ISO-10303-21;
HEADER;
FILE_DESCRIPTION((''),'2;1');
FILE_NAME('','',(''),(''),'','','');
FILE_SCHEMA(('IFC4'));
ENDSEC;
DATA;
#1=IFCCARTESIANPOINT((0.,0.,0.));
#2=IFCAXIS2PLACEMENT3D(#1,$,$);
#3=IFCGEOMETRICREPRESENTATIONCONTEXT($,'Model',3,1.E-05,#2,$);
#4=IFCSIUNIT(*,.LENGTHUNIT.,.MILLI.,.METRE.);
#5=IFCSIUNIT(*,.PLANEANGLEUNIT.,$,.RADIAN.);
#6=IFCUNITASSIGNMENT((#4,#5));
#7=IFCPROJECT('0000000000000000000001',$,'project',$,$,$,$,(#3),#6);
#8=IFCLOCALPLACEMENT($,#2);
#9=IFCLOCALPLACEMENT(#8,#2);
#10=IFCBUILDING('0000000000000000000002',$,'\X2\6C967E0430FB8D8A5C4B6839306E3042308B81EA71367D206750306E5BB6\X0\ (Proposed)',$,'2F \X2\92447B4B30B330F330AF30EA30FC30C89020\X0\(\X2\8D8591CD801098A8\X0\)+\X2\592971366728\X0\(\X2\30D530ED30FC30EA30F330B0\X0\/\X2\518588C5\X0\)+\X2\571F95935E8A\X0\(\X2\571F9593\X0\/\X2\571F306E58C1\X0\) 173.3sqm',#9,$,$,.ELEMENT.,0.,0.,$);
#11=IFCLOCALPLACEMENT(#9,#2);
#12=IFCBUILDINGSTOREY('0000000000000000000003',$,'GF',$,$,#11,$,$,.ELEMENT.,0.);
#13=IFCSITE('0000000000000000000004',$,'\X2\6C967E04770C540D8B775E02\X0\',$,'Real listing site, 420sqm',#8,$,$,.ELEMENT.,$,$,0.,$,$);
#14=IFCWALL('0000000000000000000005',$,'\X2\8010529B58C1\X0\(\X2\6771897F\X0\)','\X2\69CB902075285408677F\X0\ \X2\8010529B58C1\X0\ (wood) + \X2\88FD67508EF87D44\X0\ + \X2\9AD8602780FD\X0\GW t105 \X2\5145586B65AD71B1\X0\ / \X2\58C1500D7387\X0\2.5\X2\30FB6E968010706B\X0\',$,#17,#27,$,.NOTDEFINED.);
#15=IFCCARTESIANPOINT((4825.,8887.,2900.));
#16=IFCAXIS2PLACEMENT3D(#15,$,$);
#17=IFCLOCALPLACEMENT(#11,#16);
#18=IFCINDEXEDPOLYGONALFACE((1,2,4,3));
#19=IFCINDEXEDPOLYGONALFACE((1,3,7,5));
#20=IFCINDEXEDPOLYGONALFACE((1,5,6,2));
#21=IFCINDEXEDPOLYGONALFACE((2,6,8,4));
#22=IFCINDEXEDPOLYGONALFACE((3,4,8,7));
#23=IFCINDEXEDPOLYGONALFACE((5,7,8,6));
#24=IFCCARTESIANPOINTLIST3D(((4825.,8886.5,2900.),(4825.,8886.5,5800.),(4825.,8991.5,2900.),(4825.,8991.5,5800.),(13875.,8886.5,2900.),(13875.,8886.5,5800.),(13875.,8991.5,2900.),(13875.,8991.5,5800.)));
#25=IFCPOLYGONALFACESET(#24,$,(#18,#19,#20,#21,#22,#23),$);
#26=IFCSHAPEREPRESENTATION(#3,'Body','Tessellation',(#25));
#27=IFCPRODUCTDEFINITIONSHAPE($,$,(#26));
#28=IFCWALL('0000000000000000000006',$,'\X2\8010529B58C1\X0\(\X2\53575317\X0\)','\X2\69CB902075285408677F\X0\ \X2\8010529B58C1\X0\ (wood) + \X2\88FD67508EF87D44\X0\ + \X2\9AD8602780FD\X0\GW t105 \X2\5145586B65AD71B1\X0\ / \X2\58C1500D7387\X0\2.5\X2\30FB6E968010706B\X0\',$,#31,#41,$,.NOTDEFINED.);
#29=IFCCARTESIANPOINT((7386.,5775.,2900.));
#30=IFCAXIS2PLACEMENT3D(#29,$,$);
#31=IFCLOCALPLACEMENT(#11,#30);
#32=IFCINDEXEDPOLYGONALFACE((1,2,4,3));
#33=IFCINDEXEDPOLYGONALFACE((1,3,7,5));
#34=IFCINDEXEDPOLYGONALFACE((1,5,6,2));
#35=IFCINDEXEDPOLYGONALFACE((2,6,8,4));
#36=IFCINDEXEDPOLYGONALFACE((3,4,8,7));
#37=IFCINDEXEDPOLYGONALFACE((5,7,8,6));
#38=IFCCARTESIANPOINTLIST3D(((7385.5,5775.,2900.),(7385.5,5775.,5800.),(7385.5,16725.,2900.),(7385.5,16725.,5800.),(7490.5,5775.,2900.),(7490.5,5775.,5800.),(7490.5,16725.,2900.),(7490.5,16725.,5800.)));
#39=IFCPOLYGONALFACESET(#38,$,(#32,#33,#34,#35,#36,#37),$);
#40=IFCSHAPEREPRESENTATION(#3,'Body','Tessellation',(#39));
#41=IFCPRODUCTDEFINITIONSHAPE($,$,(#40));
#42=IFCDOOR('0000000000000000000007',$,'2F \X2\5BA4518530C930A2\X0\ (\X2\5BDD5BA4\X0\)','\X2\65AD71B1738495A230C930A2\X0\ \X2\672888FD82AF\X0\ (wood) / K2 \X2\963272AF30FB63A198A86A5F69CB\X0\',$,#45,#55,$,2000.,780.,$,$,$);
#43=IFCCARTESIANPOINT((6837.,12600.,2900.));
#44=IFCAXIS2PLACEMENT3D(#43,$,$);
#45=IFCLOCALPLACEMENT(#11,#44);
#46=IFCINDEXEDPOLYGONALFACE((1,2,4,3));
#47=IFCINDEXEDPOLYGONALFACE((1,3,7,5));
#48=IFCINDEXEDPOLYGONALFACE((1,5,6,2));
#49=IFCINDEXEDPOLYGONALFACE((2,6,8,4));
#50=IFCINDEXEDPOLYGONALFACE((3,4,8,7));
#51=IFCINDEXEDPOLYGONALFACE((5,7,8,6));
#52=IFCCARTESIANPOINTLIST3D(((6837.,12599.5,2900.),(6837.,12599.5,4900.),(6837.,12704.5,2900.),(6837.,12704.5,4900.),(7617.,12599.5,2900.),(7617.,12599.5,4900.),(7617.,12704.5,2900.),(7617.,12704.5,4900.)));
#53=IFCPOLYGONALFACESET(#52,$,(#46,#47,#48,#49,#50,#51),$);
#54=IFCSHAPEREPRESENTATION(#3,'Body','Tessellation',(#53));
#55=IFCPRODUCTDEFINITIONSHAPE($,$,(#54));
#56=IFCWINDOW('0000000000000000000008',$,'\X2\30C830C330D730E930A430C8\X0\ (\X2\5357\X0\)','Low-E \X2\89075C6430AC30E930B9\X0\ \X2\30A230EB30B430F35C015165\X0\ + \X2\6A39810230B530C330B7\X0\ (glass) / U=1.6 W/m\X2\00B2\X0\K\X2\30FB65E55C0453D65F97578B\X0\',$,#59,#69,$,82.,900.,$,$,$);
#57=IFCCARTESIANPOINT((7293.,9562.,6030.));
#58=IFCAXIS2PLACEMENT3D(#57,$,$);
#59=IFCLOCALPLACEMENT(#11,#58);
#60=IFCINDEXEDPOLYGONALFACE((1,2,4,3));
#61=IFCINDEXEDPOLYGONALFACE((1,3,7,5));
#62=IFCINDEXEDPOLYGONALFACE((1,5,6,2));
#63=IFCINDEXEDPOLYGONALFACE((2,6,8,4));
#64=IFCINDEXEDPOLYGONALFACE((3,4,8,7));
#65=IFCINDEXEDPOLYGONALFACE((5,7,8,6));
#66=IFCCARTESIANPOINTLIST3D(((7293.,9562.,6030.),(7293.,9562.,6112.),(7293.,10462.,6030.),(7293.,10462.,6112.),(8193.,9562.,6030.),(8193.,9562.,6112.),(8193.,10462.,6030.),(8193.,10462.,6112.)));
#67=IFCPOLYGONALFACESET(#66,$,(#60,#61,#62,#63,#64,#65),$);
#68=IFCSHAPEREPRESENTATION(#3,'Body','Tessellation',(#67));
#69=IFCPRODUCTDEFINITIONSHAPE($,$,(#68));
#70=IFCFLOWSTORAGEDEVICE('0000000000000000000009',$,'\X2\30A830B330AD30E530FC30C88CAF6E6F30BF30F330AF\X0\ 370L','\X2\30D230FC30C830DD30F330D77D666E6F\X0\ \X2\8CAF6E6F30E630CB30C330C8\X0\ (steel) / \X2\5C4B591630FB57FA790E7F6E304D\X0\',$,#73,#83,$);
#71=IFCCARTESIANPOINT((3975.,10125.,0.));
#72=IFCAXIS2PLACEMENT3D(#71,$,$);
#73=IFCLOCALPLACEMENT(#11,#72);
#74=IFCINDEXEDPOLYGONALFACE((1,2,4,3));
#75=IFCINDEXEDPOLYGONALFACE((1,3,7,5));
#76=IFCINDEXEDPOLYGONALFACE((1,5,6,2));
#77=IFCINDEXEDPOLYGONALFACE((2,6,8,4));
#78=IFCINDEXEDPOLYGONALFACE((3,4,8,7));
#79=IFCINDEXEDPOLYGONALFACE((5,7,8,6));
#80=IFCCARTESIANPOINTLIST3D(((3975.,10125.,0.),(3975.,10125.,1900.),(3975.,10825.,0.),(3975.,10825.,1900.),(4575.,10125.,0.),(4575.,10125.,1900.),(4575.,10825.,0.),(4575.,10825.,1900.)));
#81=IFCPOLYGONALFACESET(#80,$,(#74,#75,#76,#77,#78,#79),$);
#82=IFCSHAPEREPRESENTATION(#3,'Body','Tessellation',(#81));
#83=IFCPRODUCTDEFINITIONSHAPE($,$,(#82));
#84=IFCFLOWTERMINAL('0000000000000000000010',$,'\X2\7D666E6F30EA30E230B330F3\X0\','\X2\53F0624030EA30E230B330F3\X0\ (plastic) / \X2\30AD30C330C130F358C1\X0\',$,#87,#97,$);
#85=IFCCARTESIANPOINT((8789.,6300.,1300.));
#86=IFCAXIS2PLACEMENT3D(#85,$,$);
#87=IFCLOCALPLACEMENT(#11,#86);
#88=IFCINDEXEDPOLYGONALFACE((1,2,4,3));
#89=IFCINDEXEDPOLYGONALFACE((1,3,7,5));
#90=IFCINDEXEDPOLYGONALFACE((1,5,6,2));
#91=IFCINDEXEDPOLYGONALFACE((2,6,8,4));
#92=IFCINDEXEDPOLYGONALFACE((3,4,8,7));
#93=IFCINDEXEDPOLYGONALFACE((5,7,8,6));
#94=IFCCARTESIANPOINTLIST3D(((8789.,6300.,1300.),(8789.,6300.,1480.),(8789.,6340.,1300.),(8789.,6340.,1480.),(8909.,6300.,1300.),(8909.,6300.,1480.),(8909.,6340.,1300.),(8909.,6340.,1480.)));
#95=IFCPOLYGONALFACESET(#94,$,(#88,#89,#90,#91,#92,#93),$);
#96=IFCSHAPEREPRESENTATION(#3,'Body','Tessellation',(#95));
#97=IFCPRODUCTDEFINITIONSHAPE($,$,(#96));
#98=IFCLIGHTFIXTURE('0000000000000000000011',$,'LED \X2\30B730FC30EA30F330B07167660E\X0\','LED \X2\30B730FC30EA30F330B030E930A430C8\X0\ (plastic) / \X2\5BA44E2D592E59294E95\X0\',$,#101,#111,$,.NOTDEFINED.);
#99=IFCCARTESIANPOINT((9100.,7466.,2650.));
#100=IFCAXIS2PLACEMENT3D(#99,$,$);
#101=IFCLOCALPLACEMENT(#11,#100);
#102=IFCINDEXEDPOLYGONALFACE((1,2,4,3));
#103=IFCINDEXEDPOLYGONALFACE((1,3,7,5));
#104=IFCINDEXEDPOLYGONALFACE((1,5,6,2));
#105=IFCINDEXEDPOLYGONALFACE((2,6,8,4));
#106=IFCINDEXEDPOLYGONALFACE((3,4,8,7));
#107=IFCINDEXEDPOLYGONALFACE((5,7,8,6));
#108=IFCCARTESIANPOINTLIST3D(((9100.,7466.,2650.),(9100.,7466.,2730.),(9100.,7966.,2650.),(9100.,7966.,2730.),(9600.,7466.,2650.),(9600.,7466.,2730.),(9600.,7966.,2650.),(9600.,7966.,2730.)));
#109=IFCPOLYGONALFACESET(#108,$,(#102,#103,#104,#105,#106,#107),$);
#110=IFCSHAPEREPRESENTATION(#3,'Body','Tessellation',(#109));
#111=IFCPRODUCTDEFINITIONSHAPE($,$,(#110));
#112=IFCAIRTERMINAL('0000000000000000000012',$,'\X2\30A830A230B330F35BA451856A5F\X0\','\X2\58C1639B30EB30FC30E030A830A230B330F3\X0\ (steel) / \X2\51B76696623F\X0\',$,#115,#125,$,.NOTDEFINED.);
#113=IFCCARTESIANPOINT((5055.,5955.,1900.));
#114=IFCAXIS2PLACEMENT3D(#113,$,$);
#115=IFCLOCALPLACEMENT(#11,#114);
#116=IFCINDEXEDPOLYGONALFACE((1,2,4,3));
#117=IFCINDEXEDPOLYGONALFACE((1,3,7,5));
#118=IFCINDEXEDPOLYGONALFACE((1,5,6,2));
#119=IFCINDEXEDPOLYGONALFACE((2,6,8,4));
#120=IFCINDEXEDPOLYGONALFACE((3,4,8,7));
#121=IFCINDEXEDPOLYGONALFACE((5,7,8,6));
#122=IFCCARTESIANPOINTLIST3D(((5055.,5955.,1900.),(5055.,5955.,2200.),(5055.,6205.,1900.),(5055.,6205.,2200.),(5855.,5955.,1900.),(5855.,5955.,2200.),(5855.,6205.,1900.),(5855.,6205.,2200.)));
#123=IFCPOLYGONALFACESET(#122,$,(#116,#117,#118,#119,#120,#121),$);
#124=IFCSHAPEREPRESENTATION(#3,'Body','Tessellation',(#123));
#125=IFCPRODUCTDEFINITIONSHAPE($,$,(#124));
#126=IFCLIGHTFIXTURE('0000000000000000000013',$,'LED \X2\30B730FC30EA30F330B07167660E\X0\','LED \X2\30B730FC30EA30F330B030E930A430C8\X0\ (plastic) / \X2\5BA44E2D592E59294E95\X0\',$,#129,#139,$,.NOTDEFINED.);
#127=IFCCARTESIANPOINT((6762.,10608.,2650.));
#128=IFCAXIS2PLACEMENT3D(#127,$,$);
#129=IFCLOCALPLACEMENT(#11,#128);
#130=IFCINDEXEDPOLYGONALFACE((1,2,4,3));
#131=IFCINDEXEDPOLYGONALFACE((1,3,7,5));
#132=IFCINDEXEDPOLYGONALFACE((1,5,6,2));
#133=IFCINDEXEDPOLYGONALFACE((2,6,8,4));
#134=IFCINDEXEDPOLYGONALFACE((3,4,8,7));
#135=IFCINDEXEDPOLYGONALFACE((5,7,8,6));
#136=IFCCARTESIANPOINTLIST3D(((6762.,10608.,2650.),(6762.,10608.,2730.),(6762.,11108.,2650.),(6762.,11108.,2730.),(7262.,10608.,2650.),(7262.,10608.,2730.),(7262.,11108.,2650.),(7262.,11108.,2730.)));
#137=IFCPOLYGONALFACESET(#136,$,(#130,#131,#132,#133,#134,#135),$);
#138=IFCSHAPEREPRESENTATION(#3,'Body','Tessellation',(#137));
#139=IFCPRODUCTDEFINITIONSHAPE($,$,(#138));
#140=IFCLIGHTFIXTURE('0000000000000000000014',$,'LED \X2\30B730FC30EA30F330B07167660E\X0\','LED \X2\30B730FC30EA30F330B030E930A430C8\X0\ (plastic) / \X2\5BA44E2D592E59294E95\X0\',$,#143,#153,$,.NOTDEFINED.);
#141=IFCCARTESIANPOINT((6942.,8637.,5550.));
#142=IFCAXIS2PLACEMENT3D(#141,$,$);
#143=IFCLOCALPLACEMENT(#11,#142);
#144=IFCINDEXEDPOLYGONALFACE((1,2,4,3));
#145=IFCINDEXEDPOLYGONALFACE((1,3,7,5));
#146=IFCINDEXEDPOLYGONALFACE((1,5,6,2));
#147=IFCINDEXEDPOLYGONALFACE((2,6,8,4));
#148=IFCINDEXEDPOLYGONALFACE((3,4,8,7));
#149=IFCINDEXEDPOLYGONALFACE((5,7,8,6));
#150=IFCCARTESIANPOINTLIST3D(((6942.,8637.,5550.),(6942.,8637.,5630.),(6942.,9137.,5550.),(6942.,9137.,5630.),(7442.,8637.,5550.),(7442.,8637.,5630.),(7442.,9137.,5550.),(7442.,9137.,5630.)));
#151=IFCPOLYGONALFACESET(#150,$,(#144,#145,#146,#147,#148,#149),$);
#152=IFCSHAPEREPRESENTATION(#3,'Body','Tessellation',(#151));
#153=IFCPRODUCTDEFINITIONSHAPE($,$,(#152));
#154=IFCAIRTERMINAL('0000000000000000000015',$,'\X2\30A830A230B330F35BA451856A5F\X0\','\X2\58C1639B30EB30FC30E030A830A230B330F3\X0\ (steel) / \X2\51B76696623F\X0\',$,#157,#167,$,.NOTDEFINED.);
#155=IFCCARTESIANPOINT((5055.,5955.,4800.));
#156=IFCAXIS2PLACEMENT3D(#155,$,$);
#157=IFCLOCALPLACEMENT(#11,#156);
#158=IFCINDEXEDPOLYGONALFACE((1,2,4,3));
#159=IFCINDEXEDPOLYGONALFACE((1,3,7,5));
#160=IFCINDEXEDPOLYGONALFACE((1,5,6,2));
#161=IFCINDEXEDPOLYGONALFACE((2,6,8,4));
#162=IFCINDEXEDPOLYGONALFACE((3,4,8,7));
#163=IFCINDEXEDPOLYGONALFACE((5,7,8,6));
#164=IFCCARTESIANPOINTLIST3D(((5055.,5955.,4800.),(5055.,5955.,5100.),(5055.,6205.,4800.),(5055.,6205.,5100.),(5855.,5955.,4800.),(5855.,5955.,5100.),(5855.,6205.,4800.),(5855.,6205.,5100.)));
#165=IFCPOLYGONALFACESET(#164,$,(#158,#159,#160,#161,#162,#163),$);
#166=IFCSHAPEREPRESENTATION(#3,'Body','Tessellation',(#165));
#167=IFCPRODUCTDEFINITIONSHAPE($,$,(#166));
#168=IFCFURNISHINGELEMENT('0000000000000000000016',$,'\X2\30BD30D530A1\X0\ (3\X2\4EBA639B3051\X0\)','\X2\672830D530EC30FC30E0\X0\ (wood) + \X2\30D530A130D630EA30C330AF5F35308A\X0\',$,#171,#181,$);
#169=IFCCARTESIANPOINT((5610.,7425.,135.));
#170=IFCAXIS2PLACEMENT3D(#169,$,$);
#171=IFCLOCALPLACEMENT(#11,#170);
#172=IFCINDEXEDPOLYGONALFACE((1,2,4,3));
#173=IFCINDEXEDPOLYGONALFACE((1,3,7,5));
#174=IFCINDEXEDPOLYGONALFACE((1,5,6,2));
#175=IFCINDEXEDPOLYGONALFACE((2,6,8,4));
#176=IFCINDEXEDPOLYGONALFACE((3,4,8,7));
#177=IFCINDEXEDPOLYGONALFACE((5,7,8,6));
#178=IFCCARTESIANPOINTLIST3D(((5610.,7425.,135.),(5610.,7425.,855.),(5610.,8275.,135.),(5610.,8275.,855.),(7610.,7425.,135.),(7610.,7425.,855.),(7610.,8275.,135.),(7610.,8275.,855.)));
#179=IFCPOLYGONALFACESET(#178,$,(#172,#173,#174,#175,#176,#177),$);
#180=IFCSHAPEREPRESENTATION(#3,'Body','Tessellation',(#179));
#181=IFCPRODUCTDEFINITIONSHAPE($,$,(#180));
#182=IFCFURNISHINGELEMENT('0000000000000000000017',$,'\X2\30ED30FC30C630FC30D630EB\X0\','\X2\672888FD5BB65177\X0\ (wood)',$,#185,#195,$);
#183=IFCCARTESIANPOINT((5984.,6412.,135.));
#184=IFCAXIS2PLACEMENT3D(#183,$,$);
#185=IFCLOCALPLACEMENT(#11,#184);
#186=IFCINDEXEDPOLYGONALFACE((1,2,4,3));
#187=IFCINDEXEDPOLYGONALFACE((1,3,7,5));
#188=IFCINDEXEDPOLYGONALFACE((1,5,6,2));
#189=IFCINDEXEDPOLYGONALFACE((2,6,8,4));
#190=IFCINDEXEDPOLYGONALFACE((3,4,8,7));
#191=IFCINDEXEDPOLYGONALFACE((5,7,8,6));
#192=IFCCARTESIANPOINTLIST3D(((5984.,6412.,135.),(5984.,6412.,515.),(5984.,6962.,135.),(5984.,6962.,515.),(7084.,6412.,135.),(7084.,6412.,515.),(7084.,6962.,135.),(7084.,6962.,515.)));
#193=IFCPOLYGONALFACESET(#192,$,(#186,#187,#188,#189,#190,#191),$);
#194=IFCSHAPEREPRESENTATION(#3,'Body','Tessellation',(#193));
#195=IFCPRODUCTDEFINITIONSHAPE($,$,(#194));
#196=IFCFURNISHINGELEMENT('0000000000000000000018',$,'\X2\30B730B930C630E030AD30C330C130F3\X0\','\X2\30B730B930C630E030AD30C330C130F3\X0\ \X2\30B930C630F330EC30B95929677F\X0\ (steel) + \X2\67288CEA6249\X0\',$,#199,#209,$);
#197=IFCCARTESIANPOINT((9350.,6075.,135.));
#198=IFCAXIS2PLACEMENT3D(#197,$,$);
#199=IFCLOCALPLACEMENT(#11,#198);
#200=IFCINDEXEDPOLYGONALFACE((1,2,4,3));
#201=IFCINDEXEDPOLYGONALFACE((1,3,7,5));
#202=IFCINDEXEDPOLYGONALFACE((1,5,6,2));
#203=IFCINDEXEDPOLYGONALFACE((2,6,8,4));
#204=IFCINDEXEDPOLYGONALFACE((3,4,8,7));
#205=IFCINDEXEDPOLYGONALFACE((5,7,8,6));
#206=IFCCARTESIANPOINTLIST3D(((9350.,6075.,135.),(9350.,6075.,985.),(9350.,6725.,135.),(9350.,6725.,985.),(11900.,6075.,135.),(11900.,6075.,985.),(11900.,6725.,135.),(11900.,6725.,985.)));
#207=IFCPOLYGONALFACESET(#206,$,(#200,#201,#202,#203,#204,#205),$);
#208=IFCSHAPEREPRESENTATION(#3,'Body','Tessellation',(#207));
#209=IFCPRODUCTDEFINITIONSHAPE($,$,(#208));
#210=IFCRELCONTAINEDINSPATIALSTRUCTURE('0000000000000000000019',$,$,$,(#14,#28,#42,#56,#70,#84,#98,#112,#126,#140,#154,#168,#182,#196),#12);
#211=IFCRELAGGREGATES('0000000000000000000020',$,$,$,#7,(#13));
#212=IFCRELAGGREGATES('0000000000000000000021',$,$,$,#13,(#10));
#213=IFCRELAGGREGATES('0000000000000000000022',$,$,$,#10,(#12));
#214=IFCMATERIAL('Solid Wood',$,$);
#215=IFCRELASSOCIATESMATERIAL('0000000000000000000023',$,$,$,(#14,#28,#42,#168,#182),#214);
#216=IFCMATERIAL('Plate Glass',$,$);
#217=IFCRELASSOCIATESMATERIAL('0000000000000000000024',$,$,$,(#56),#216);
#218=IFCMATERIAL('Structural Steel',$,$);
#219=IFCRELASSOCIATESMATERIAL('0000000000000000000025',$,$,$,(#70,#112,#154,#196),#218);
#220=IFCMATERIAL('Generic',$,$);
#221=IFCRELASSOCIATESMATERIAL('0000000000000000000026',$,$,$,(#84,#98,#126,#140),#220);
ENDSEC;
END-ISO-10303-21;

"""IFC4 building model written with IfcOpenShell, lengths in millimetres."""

from ifc_helpers import new_model, si_unit, frame, frame_2d, origin, place, context, project, spatial, rectangle, extrude, material, element, fill, save


model = new_model("IFC4")

# Units and contexts
model_context = context("Model", 3, precision=1e-05, world=origin())
ifc_project = project(units=[si_unit("LENGTHUNIT", "METRE", prefix="MILLI"), si_unit("PLANEANGLEUNIT", "RADIAN")], contexts=[model_context])

# Site, building, storey
site_placement = place(None, origin())
site = spatial("IfcSite", under=ifc_project, at=site_placement, Name="沖縄県名護市", ObjectType="Real listing site, 420sqm", CompositionType="ELEMENT", RefElevation=0.0)
building_placement = place(site_placement, origin())
building = spatial("IfcBuilding", under=site, at=building_placement, Name="沖縄・越屋根のある自然素材の家 (Proposed)", ObjectType="2F 鉄筋コンクリート造(超重耐風)+天然木(フローリング/内装)+土間床(土間/土の壁) 173.3sqm", CompositionType="ELEMENT", ElevationOfRefHeight=0.0, ElevationOfTerrain=0.0)
storey_placement = place(building_placement, origin())
storey = spatial("IfcBuildingStorey", under=building, at=storey_placement, Name="GF", CompositionType="ELEMENT", Elevation=0.0)

# Shared definitions
ifc_material_1 = material(Name="Solid Wood")

# Wall
wall_1_placement = place(storey_placement, frame((4825.0, 8887.0, 2900.0)))
element("IfcWall", 1, at=wall_1_placement, inside=storey, material=ifc_material_1, Name="耐力壁(東西)", Description="構造用合板 耐力壁 (wood) + 製材軸組 + 高性能GW t105 充填断熱 / 壁倍率2.5・準耐火", PredefinedType="NOTDEFINED", context=model_context, shape_type="SweptSolid", body=[
    extrude(rectangle(XDim=9050.0, YDim=105.0, at=frame_2d((4525.0, 52.0))), frame((4825.0, 8887.0, 2900.0)), (0.0, 0.0, 1.0), 2900.0),
])

# Wall, opening, door
wall_2_placement = place(storey_placement, frame((7386.0, 5775.0, 2900.0)))
wall_2 = element("IfcWall", 2, at=wall_2_placement, inside=storey, material=ifc_material_1, Name="耐力壁(南北)", Description="構造用合板 耐力壁 (wood) + 製材軸組 + 高性能GW t105 充填断熱 / 壁倍率2.5・準耐火", PredefinedType="NOTDEFINED", context=model_context, shape_type="SweptSolid", body=[
    extrude(rectangle(XDim=105.0, YDim=10950.0, at=frame_2d((52.0, 5475.0))), frame((7386.0, 5775.0, 2900.0)), (0.0, 0.0, 1.0), 2900.0),
])
opening_placement = place(storey_placement, frame((6837.0, 12600.0, 2900.0)))
opening = element("IfcOpeningElement", 3, at=opening_placement, cuts=wall_2, PredefinedType="NOTDEFINED", context=model_context, shape_type="SweptSolid", body=[
    extrude(rectangle(XDim=780.0, YDim=105.0, at=frame_2d((390.0, 52.0))), frame((6837.0, 12600.0, 2900.0)), (0.0, 0.0, 1.0), 2000.0),
])
door_placement = place(storey_placement, frame((6837.0, 12600.0, 2900.0)))
door = element("IfcDoor", 4, at=door_placement, inside=storey, material=ifc_material_1, Name="2F 室内ドア (寝室)", Description="断熱玄関ドア 木製芯 (wood) / K2 防犯・採風機構", OverallHeight=2000.0, OverallWidth=780.0, context=model_context, shape_type="SweptSolid", body=[
    extrude(rectangle(XDim=780.0, YDim=105.0, at=frame_2d((390.0, 52.0))), frame((6837.0, 12600.0, 2900.0)), (0.0, 0.0, 1.0), 2000.0),
])
fill(opening, door)

# Window
ifc_material_2 = material(Name="Plate Glass")
window_placement = place(storey_placement, frame((7293.0, 9562.0, 6030.0)))
element("IfcWindow", 5, at=window_placement, inside=storey, material=ifc_material_2, Name="トップライト (南)", Description="Low-E 複層ガラス アルゴン封入 + 樹脂サッシ (glass) / U=1.6 W/m²K・日射取得型", OverallHeight=82.0, OverallWidth=900.0, context=model_context, shape_type="SweptSolid", body=[
    extrude(rectangle(XDim=900.0, YDim=900.0, at=frame_2d((450.0, 450.0))), frame((7293.0, 9562.0, 6030.0)), (0.0, 0.0, 1.0), 82.0),
])

# Flow storage device
ifc_material_3 = material(Name="Structural Steel")
flow_storage_device_placement = place(storey_placement, frame((3975.0, 10125.0, 0.0)))
element("IfcFlowStorageDevice", 6, at=flow_storage_device_placement, inside=storey, material=ifc_material_3, Name="エコキュート貯湯タンク 370L", Description="ヒートポンプ給湯 貯湯ユニット (steel) / 屋外・基礎置き", context=model_context, shape_type="SweptSolid", body=[
    extrude(rectangle(XDim=600.0, YDim=700.0, at=frame_2d((300.0, 350.0))), frame((3975.0, 10125.0, 0.0)), (0.0, 0.0, 1.0), 1900.0),
])

# Flow terminal
ifc_material_4 = material(Name="Generic")
flow_terminal_placement = place(storey_placement, frame((8789.0, 6300.0, 1300.0)))
element("IfcFlowTerminal", 7, at=flow_terminal_placement, inside=storey, material=ifc_material_4, Name="給湯リモコン", Description="台所リモコン (plastic) / キッチン壁", context=model_context, shape_type="SweptSolid", body=[
    extrude(rectangle(XDim=120.0, YDim=40.0, at=frame_2d((60.0, 20.0))), frame((8789.0, 6300.0, 1300.0)), (0.0, 0.0, 1.0), 180.0),
])

# Light fixture
light_fixture_1_placement = place(storey_placement, frame((9100.0, 7466.0, 2650.0)))
element("IfcLightFixture", 8, at=light_fixture_1_placement, inside=storey, material=ifc_material_4, Name="LED シーリング照明", Description="LED シーリングライト (plastic) / 室中央天井", PredefinedType="NOTDEFINED", context=model_context, shape_type="SweptSolid", body=[
    extrude(rectangle(XDim=500.0, YDim=500.0, at=frame_2d((250.0, 250.0))), frame((9100.0, 7466.0, 2650.0)), (0.0, 0.0, 1.0), 80.0),
])

# Air terminal
air_terminal_1_placement = place(storey_placement, frame((5055.0, 5955.0, 1900.0)))
element("IfcAirTerminal", 9, at=air_terminal_1_placement, inside=storey, material=ifc_material_3, Name="エアコン室内機", Description="壁掛ルームエアコン (steel) / 冷暖房", PredefinedType="NOTDEFINED", context=model_context, shape_type="SweptSolid", body=[
    extrude(rectangle(XDim=800.0, YDim=250.0, at=frame_2d((400.0, 125.0))), frame((5055.0, 5955.0, 1900.0)), (0.0, 0.0, 1.0), 300.0),
])

# Light fixtures
light_fixture_2_placement = place(storey_placement, frame((6762.0, 10608.0, 2650.0)))
element("IfcLightFixture", 10, at=light_fixture_2_placement, inside=storey, material=ifc_material_4, Name="LED シーリング照明", Description="LED シーリングライト (plastic) / 室中央天井", PredefinedType="NOTDEFINED", context=model_context, shape_type="SweptSolid", body=[
    extrude(rectangle(XDim=500.0, YDim=500.0, at=frame_2d((250.0, 250.0))), frame((6762.0, 10608.0, 2650.0)), (0.0, 0.0, 1.0), 80.0),
])
light_fixture_3_placement = place(storey_placement, frame((6942.0, 8637.0, 5550.0)))
element("IfcLightFixture", 11, at=light_fixture_3_placement, inside=storey, material=ifc_material_4, Name="LED シーリング照明", Description="LED シーリングライト (plastic) / 室中央天井", PredefinedType="NOTDEFINED", context=model_context, shape_type="SweptSolid", body=[
    extrude(rectangle(XDim=500.0, YDim=500.0, at=frame_2d((250.0, 250.0))), frame((6942.0, 8637.0, 5550.0)), (0.0, 0.0, 1.0), 80.0),
])

# Air terminal
air_terminal_2_placement = place(storey_placement, frame((5055.0, 5955.0, 4800.0)))
element("IfcAirTerminal", 12, at=air_terminal_2_placement, inside=storey, material=ifc_material_3, Name="エアコン室内機", Description="壁掛ルームエアコン (steel) / 冷暖房", PredefinedType="NOTDEFINED", context=model_context, shape_type="SweptSolid", body=[
    extrude(rectangle(XDim=800.0, YDim=250.0, at=frame_2d((400.0, 125.0))), frame((5055.0, 5955.0, 4800.0)), (0.0, 0.0, 1.0), 300.0),
])

# Furnishing elements
furnishing_1_placement = place(storey_placement, frame((5610.0, 7425.0, 135.0)))
element("IfcFurnishingElement", 13, at=furnishing_1_placement, inside=storey, material=ifc_material_1, Name="ソファ (3人掛け)", Description="木フレーム (wood) + ファブリック張り", context=model_context, shape_type="SweptSolid", body=[
    extrude(rectangle(XDim=2000.0, YDim=850.0, at=frame_2d((1000.0, 425.0))), frame((5610.0, 7425.0, 135.0)), (0.0, 0.0, 1.0), 720.0),
])
furnishing_2_placement = place(storey_placement, frame((5984.0, 6412.0, 135.0)))
element("IfcFurnishingElement", 14, at=furnishing_2_placement, inside=storey, material=ifc_material_1, Name="ローテーブル", Description="木製家具 (wood)", context=model_context, shape_type="SweptSolid", body=[
    extrude(rectangle(XDim=1100.0, YDim=550.0, at=frame_2d((550.0, 275.0))), frame((5984.0, 6412.0, 135.0)), (0.0, 0.0, 1.0), 380.0),
])
furnishing_3_placement = place(storey_placement, frame((9350.0, 6075.0, 135.0)))
element("IfcFurnishingElement", 15, at=furnishing_3_placement, inside=storey, material=ifc_material_3, Name="システムキッチン", Description="システムキッチン ステンレス天板 (steel) + 木質扉", context=model_context, shape_type="SweptSolid", body=[
    extrude(rectangle(XDim=2550.0, YDim=650.0, at=frame_2d((1275.0, 325.0))), frame((9350.0, 6075.0, 135.0)), (0.0, 0.0, 1.0), 850.0),
])

save(model, "model.ifc")
